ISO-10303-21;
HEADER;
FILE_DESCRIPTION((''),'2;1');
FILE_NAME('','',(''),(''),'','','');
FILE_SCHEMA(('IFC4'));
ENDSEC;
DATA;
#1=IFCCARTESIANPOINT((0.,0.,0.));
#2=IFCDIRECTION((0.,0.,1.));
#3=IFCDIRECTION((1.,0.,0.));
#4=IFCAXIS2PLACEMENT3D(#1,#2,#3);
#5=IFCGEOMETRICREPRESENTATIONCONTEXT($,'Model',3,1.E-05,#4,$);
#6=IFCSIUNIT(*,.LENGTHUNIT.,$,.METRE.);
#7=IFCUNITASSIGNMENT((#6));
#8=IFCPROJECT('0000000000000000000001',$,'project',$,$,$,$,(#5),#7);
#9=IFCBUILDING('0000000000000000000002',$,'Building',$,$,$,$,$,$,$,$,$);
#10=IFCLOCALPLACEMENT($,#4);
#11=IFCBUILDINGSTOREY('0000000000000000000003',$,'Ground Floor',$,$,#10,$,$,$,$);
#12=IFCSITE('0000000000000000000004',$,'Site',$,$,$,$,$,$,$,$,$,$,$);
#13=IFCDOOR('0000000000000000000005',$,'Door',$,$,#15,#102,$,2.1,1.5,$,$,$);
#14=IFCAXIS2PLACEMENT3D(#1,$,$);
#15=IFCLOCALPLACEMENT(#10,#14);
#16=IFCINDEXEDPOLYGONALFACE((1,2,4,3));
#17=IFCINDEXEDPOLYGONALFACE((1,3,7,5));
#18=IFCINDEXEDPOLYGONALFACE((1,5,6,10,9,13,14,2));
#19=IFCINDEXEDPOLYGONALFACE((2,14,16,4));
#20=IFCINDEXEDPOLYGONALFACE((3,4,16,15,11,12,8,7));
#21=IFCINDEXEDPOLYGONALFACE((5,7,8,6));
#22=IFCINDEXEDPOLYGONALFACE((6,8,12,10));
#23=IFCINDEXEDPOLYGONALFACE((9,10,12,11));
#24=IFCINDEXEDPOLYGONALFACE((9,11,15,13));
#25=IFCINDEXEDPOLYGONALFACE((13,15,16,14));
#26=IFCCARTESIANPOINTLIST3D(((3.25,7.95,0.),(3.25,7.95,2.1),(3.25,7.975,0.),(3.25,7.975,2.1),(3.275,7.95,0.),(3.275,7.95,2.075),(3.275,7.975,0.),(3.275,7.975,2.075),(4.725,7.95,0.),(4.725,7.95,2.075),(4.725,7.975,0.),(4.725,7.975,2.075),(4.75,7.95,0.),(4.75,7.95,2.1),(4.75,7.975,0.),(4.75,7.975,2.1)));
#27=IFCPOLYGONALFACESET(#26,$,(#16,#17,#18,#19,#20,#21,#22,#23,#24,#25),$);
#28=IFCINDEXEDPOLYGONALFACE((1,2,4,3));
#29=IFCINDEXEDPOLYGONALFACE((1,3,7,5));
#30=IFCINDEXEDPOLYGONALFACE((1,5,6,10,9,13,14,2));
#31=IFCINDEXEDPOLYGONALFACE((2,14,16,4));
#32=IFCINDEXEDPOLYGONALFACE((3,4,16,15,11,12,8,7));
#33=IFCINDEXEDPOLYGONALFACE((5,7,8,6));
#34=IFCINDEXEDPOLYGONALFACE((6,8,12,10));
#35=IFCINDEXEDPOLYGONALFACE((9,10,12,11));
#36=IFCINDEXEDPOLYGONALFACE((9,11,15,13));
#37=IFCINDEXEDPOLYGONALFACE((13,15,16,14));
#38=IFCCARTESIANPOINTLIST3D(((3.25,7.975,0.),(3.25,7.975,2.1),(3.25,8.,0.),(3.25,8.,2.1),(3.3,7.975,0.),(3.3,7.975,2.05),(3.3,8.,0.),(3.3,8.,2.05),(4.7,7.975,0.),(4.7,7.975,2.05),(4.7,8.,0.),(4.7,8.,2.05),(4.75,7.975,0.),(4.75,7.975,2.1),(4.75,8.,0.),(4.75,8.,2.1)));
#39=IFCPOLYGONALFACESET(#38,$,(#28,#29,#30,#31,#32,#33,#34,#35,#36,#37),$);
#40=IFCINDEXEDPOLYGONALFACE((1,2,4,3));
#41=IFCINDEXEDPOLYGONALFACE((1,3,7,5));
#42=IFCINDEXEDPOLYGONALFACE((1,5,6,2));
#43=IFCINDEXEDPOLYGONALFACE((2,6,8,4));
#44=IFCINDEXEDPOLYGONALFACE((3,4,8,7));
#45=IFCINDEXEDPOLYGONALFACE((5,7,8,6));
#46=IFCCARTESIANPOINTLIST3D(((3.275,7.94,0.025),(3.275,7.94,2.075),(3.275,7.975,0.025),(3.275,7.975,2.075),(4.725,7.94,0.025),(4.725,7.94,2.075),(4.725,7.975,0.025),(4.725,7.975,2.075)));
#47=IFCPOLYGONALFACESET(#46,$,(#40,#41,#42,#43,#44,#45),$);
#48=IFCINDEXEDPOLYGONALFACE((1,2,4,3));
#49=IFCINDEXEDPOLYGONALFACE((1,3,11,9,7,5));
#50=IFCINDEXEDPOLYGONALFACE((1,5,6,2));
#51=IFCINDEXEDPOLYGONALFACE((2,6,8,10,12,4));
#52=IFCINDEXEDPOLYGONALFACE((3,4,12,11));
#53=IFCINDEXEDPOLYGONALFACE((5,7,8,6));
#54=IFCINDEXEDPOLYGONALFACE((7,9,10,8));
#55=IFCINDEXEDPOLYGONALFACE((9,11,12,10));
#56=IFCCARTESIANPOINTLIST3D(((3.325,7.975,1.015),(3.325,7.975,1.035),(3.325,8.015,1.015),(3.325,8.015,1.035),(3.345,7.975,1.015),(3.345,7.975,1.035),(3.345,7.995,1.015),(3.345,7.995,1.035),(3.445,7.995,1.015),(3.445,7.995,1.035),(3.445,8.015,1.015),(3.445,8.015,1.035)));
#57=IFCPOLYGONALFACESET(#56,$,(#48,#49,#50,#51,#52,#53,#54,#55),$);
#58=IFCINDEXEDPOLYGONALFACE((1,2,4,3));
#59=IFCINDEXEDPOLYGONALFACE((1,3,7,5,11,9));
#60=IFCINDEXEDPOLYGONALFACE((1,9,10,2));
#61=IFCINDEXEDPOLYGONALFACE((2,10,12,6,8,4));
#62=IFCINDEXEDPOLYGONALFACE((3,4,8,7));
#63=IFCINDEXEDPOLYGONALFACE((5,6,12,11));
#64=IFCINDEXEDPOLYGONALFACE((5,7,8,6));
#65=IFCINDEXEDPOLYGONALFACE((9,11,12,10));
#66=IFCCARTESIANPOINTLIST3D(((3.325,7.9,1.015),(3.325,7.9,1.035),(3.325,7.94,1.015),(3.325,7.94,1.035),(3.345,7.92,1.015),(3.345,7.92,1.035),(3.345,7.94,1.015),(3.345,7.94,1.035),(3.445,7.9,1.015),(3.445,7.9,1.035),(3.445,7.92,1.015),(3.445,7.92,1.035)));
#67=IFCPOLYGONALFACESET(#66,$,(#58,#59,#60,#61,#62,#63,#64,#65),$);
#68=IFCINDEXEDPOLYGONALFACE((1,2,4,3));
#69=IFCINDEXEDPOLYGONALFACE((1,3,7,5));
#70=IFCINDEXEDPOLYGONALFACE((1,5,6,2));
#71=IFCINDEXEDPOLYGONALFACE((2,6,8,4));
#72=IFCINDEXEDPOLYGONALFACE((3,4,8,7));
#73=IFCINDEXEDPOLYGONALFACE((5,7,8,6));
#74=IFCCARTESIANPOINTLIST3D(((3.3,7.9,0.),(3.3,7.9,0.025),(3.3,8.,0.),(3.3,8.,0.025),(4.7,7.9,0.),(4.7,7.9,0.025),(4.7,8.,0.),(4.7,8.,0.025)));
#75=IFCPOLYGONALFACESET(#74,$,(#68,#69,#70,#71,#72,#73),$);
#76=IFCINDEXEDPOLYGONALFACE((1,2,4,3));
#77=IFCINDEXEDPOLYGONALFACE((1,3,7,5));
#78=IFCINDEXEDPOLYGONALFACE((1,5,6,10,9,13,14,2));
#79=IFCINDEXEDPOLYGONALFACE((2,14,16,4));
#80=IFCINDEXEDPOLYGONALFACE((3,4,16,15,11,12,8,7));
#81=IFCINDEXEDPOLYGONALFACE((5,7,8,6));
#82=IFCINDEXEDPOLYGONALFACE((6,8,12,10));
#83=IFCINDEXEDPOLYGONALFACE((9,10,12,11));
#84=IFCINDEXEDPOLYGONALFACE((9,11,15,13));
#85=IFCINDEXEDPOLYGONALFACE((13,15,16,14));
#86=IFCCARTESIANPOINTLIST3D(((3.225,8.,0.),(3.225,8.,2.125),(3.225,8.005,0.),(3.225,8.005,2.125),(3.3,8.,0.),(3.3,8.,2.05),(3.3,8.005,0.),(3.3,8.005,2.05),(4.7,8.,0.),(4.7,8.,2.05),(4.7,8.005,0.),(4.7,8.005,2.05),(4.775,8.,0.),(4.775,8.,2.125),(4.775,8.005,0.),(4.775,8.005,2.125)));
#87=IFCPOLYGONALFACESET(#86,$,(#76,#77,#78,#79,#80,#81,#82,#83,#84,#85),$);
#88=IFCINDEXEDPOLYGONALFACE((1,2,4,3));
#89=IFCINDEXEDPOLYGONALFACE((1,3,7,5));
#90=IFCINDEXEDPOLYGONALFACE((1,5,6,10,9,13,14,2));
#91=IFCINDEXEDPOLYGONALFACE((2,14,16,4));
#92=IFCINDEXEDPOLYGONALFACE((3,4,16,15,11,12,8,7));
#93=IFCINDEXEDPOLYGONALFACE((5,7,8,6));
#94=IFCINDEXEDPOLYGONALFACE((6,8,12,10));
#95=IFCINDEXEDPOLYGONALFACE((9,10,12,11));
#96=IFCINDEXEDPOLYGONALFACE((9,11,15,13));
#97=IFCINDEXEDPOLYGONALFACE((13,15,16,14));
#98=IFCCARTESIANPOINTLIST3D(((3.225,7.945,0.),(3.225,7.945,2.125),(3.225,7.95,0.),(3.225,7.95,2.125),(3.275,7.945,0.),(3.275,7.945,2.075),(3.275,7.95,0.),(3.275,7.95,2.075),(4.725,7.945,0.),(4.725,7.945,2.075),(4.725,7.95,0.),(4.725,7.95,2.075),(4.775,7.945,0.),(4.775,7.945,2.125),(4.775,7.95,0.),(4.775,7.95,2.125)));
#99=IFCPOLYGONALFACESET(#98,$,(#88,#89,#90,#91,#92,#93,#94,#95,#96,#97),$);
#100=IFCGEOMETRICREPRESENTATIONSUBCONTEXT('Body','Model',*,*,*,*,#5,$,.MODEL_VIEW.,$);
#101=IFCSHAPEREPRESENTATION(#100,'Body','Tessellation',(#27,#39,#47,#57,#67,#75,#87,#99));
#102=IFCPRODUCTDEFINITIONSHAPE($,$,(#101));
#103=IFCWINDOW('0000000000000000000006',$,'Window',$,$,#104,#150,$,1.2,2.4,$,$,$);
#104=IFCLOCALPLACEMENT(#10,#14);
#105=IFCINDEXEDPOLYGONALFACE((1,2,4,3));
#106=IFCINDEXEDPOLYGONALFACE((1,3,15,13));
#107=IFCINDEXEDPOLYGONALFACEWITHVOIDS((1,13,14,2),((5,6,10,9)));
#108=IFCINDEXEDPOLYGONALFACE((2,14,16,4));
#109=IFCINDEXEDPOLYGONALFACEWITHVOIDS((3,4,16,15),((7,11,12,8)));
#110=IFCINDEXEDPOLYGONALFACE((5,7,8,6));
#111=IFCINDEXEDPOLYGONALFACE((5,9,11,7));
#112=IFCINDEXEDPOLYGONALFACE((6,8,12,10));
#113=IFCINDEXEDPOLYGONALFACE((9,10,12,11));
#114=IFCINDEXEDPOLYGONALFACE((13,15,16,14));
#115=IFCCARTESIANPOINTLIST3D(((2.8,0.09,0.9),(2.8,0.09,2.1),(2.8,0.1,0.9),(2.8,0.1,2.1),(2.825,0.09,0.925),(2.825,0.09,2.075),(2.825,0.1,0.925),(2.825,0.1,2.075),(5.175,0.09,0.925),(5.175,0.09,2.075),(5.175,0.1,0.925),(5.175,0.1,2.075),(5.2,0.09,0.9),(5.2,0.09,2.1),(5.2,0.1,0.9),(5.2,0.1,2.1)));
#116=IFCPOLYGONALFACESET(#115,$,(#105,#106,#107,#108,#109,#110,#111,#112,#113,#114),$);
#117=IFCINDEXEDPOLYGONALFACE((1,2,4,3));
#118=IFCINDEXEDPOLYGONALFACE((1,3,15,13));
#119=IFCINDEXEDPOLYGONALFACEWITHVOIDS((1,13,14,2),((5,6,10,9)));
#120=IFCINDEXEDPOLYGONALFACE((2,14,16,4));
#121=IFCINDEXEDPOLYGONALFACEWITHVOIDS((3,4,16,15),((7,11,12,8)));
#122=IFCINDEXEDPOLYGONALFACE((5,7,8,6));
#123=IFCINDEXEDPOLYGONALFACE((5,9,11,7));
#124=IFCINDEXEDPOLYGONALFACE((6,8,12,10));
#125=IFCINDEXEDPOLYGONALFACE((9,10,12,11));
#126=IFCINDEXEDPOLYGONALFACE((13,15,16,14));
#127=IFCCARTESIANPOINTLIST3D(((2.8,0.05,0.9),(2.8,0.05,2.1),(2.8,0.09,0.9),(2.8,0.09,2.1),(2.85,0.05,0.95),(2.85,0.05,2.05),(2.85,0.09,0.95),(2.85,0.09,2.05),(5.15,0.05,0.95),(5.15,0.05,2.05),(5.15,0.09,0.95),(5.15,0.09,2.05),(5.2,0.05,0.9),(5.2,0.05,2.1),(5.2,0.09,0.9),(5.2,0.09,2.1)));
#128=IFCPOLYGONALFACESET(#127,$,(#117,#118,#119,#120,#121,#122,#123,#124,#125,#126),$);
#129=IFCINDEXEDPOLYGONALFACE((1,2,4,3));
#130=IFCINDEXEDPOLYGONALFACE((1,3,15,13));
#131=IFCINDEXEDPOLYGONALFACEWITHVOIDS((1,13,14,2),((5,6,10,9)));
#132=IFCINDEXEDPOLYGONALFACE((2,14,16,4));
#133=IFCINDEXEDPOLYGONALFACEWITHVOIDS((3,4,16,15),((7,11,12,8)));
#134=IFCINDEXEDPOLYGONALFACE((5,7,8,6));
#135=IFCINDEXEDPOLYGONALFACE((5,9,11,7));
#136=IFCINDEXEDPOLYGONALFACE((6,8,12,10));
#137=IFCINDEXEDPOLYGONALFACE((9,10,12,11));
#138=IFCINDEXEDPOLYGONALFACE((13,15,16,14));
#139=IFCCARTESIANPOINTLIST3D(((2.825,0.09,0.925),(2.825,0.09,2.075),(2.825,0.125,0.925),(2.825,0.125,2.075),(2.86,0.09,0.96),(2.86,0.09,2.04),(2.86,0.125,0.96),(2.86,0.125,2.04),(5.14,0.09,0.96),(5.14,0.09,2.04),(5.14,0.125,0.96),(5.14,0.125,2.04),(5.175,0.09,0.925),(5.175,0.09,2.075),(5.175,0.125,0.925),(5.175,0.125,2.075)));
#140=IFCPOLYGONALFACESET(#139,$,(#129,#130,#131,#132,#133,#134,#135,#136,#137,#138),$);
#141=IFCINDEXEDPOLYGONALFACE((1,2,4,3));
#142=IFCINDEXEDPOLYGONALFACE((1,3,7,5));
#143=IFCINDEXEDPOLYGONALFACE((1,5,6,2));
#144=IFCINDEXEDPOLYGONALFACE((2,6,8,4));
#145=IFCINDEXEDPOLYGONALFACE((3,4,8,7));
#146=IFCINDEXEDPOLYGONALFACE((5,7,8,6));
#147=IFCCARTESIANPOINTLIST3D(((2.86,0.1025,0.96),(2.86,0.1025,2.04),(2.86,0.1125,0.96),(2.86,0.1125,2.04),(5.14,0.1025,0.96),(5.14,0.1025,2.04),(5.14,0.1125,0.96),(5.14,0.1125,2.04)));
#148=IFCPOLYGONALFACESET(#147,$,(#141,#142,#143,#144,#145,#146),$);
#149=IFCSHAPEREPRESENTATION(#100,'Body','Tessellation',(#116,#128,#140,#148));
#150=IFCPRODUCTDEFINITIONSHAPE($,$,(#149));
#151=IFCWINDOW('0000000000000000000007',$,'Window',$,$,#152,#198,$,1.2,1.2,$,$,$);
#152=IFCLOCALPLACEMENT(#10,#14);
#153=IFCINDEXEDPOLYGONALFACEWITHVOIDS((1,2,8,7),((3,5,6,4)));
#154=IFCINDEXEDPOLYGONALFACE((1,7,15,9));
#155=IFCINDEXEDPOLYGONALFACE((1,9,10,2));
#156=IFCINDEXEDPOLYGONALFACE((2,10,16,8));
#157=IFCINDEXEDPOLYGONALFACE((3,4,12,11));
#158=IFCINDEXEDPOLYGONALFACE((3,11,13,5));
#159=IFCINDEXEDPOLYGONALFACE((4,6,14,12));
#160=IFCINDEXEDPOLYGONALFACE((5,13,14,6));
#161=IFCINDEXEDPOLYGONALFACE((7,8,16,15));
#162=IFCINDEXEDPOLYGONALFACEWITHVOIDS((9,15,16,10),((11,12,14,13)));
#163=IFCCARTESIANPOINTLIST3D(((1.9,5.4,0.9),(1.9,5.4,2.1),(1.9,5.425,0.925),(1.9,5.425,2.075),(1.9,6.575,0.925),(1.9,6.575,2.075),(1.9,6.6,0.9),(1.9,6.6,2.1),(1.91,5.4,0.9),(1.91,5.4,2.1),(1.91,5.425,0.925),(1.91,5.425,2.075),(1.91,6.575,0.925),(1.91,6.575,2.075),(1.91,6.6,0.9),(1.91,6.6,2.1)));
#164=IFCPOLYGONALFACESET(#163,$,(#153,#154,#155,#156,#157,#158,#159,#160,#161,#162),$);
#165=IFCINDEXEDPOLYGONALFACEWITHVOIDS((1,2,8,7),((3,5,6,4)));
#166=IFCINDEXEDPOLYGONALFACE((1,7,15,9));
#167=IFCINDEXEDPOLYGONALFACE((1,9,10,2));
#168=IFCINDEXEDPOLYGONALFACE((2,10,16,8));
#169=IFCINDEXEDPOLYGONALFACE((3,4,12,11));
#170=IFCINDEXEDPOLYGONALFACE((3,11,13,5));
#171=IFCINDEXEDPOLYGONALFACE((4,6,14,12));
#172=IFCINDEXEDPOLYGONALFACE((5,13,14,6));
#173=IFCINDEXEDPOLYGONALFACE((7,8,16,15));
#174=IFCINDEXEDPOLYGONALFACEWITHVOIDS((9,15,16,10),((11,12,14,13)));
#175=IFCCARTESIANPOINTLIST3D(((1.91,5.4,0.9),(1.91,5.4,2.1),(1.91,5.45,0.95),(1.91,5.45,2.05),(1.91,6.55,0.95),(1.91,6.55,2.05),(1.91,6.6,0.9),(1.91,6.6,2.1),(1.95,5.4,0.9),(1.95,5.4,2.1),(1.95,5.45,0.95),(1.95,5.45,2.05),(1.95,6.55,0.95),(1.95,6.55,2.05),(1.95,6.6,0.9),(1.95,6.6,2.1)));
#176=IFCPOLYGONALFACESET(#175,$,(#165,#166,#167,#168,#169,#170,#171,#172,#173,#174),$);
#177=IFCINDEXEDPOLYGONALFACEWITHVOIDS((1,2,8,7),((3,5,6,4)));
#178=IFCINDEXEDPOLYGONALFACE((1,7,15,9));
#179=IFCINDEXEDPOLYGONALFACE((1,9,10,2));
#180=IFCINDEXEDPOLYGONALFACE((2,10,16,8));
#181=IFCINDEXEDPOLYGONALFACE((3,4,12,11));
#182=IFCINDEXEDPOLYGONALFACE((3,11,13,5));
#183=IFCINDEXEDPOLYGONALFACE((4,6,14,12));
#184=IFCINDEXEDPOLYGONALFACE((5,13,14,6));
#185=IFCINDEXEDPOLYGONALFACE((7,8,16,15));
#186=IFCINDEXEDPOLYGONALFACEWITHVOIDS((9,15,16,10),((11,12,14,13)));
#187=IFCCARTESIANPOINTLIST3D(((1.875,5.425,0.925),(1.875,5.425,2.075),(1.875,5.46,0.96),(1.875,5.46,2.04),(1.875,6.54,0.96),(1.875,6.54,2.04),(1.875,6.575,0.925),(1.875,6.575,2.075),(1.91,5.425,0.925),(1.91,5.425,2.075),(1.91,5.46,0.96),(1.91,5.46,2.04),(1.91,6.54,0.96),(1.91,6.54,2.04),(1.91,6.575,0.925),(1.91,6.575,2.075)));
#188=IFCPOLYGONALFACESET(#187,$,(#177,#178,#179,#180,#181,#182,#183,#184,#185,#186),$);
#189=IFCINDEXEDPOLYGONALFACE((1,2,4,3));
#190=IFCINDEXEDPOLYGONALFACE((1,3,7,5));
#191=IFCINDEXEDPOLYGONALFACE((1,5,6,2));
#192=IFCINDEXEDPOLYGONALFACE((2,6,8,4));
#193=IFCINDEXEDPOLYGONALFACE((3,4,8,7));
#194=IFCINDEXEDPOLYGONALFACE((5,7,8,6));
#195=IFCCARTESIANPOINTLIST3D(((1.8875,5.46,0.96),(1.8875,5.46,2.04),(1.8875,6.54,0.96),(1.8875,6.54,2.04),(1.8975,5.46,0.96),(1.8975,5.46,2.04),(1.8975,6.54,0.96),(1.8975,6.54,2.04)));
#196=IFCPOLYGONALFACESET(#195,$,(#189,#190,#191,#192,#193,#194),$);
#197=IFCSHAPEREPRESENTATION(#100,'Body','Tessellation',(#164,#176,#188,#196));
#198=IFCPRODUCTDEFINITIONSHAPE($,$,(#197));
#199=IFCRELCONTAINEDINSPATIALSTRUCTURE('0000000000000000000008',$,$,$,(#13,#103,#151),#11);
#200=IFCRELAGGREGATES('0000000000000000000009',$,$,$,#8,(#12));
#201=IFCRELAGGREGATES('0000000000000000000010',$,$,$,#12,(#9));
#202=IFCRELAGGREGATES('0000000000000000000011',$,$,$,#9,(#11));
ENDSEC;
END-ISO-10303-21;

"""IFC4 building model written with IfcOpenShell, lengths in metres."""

from ifc_helpers import new_model, si_unit, frame, origin_with_axes, place, context, subcontext, project, spatial, line, indexed_curve, outline, extrude, element, save


model = new_model("IFC4")

# Units and contexts
model_context = context("Model", 3, precision=1e-05, world=origin_with_axes())
body_context = subcontext(model_context, "Body", "Model", "MODEL_VIEW")
ifc_project = project(units=[si_unit("LENGTHUNIT", "METRE")], contexts=[model_context])

# Site, building, storey
site = spatial("IfcSite", under=ifc_project, Name="Site")
building = spatial("IfcBuilding", under=site, Name="Building")
storey_placement = place(None, origin_with_axes())
storey = spatial("IfcBuildingStorey", under=building, at=storey_placement, Name="Ground Floor")

# Door
door_1_placement = place(storey_placement, frame((4.75, 8.0, 0.0), z_axis=(0.0, 0.0, 1.0), x_axis=(-1.0, 0.0, 0.0)))
element("IfcDoor", 1, at=door_1_placement, inside=storey, Name="Door", OverallHeight=2.1, OverallWidth=1.5, context=body_context, shape_type="SweptSolid", body=[
    extrude(outline(indexed_curve([(0.0, 0.0), (0.0, 2.1), (1.5, 2.1), (1.5, 0.0), (1.475, 0.0), (1.475, 2.075), (0.025, 2.075), (0.025, 0.0)], segments=[line(1, 2, 3, 4, 5, 6, 7, 8, 1)])), frame((0.0, 0.025, 0.0), z_axis=(0.0, -1.0, 0.0), x_axis=(1.0, 0.0, 0.0)), (0.0, 0.0, -1.0), 0.025),
    extrude(outline(indexed_curve([(0.0, 0.0), (0.0, 2.1), (1.5, 2.1), (1.5, 0.0), (1.45, 0.0), (1.45, 2.05), (0.05, 2.05), (0.05, 0.0)], segments=[line(1, 2, 3, 4, 5, 6, 7, 8, 1)])), frame((0.0, 0.0, 0.0), z_axis=(0.0, -1.0, 0.0), x_axis=(1.0, 0.0, 0.0)), (0.0, 0.0, -1.0), 0.025),
    extrude(outline(indexed_curve([(0.0, 0.0), (1.45, 0.0), (1.45, 0.035), (0.0, 0.035)], segments=[line(1, 2, 3, 4, 1)])), frame((0.025, 0.025, 0.025), z_axis=(0.0, 0.0, 1.0), x_axis=(1.0, 0.0, 0.0)), (0.0, 0.0, 1.0), 2.05),
    extrude(outline(indexed_curve([(0.0, 0.0), (0.0, -0.04), (-0.12, -0.04), (-0.12, -0.02), (-0.02, -0.02), (-0.02, 0.0)], segments=[line(1, 2, 3, 4, 5, 6, 1)])), frame((1.425, 0.025, 1.015), z_axis=(0.0, 0.0, 1.0), x_axis=(1.0, 0.0, 0.0)), (0.0, 0.0, 1.0), 0.02),
    extrude(outline(indexed_curve([(0.0, 0.0), (0.0, 0.04), (-0.12, 0.04), (-0.12, 0.02), (-0.02, 0.02), (-0.02, 0.0)], segments=[line(1, 2, 3, 4, 5, 6, 1)])), frame((1.425, 0.06, 1.015), z_axis=(0.0, 0.0, 1.0), x_axis=(1.0, 0.0, 0.0)), (0.0, 0.0, 1.0), 0.02),
    extrude(outline(indexed_curve([(0.0, 0.0), (1.4, 0.0), (1.4, 0.1), (0.0, 0.1)], segments=[line(1, 2, 3, 4, 1)])), frame((0.05, 0.0, 0.0), z_axis=(0.0, 0.0, 1.0), x_axis=(1.0, 0.0, 0.0)), (0.0, 0.0, 1.0), 0.025),
    extrude(outline(indexed_curve([(0.0, 0.0), (0.0, 2.125), (1.55, 2.125), (1.55, 0.0), (1.475, 0.0), (1.475, 2.05), (0.075, 2.05), (0.075, 0.0)], segments=[line(1, 2, 3, 4, 5, 6, 7, 8, 1)])), frame((-0.025, -0.005, 0.0), z_axis=(0.0, -1.0, 0.0), x_axis=(1.0, 0.0, 0.0)), (0.0, 0.0, -1.0), 0.005),
    extrude(outline(indexed_curve([(0.0, 0.0), (0.0, 2.125), (1.55, 2.125), (1.55, 0.0), (1.5, 0.0), (1.5, 2.075), (0.05, 2.075), (0.05, 0.0)], segments=[line(1, 2, 3, 4, 5, 6, 7, 8, 1)])), frame((-0.025, 0.05, 0.0), z_axis=(0.0, -1.0, 0.0), x_axis=(1.0, 0.0, 0.0)), (0.0, 0.0, -1.0), 0.005),
])

# Windows
window_1_placement = place(storey_placement, frame((2.8, 0.0, 0.9), z_axis=(0.0, 0.0, 1.0), x_axis=(1.0, 0.0, 0.0)))
element("IfcWindow", 2, at=window_1_placement, inside=storey, Name="Window", OverallHeight=1.2, OverallWidth=2.4, context=body_context, shape_type="SweptSolid", body=[
    extrude(outline(indexed_curve([(0.0, 0.0), (2.4, 0.0), (2.4, 1.2), (0.0, 1.2)], segments=[line(1, 2, 3, 4, 1)]), holes=[indexed_curve([(0.025, 0.025), (2.375, 0.025), (2.375, 1.175), (0.025, 1.175)], segments=[line(1, 2, 3, 4, 1)])]), frame((0.0, 0.09, 0.0), z_axis=(0.0, -1.0, 0.0), x_axis=(1.0, 0.0, 0.0)), (0.0, 0.0, -1.0), 0.01),
    extrude(outline(indexed_curve([(0.0, 0.0), (2.4, 0.0), (2.4, 1.2), (0.0, 1.2)], segments=[line(1, 2, 3, 4, 1)]), holes=[indexed_curve([(0.05, 0.05), (2.35, 0.05), (2.35, 1.15), (0.05, 1.15)], segments=[line(1, 2, 3, 4, 1)])]), frame((0.0, 0.05, 0.0), z_axis=(0.0, -1.0, 0.0), x_axis=(1.0, 0.0, 0.0)), (0.0, 0.0, -1.0), 0.04),
    extrude(outline(indexed_curve([(0.0, 0.0), (2.35, 0.0), (2.35, 1.15), (0.0, 1.15)], segments=[line(1, 2, 3, 4, 1)]), holes=[indexed_curve([(0.035, 0.035), (2.315, 0.035), (2.315, 1.115), (0.035, 1.115)], segments=[line(1, 2, 3, 4, 1)])]), frame((0.025, 0.09, 0.025), z_axis=(0.0, -1.0, 0.0), x_axis=(1.0, 0.0, 0.0)), (0.0, 0.0, -1.0), 0.035),
    extrude(outline(indexed_curve([(0.035, 0.035), (2.315, 0.035), (2.315, 1.115), (0.035, 1.115)], segments=[line(1, 2, 3, 4, 1)])), frame((0.025, 0.1025, 0.025), z_axis=(0.0, -1.0, 0.0), x_axis=(1.0, 0.0, 0.0)), (0.0, 0.0, -1.0), 0.01),
])
window_2_placement = place(storey_placement, frame((2.0, 5.4, 0.9), z_axis=(0.0, 0.0, 1.0), x_axis=(0.0, 1.0, 0.0)))
element("IfcWindow", 3, at=window_2_placement, inside=storey, Name="Window", OverallHeight=1.2, OverallWidth=1.2, context=body_context, shape_type="SweptSolid", body=[
    extrude(outline(indexed_curve([(0.0, 0.0), (1.2, 0.0), (1.2, 1.2), (0.0, 1.2)], segments=[line(1, 2, 3, 4, 1)]), holes=[indexed_curve([(0.025, 0.025), (1.175, 0.025), (1.175, 1.175), (0.025, 1.175)], segments=[line(1, 2, 3, 4, 1)])]), frame((0.0, 0.09, 0.0), z_axis=(0.0, -1.0, 0.0), x_axis=(1.0, 0.0, 0.0)), (0.0, 0.0, -1.0), 0.01),
    extrude(outline(indexed_curve([(0.0, 0.0), (1.2, 0.0), (1.2, 1.2), (0.0, 1.2)], segments=[line(1, 2, 3, 4, 1)]), holes=[indexed_curve([(0.05, 0.05), (1.15, 0.05), (1.15, 1.15), (0.05, 1.15)], segments=[line(1, 2, 3, 4, 1)])]), frame((0.0, 0.05, 0.0), z_axis=(0.0, -1.0, 0.0), x_axis=(1.0, 0.0, 0.0)), (0.0, 0.0, -1.0), 0.04),
    extrude(outline(indexed_curve([(0.0, 0.0), (1.15, 0.0), (1.15, 1.15), (0.0, 1.15)], segments=[line(1, 2, 3, 4, 1)]), holes=[indexed_curve([(0.035, 0.035), (1.115, 0.035), (1.115, 1.115), (0.035, 1.115)], segments=[line(1, 2, 3, 4, 1)])]), frame((0.025, 0.09, 0.025), z_axis=(0.0, -1.0, 0.0), x_axis=(1.0, 0.0, 0.0)), (0.0, 0.0, -1.0), 0.035),
    extrude(outline(indexed_curve([(0.035, 0.035), (1.115, 0.035), (1.115, 1.115), (0.035, 1.115)], segments=[line(1, 2, 3, 4, 1)])), frame((0.025, 0.1025, 0.025), z_axis=(0.0, -1.0, 0.0), x_axis=(1.0, 0.0, 0.0)), (0.0, 0.0, -1.0), 0.01),
])

save(model, "model.ifc")
